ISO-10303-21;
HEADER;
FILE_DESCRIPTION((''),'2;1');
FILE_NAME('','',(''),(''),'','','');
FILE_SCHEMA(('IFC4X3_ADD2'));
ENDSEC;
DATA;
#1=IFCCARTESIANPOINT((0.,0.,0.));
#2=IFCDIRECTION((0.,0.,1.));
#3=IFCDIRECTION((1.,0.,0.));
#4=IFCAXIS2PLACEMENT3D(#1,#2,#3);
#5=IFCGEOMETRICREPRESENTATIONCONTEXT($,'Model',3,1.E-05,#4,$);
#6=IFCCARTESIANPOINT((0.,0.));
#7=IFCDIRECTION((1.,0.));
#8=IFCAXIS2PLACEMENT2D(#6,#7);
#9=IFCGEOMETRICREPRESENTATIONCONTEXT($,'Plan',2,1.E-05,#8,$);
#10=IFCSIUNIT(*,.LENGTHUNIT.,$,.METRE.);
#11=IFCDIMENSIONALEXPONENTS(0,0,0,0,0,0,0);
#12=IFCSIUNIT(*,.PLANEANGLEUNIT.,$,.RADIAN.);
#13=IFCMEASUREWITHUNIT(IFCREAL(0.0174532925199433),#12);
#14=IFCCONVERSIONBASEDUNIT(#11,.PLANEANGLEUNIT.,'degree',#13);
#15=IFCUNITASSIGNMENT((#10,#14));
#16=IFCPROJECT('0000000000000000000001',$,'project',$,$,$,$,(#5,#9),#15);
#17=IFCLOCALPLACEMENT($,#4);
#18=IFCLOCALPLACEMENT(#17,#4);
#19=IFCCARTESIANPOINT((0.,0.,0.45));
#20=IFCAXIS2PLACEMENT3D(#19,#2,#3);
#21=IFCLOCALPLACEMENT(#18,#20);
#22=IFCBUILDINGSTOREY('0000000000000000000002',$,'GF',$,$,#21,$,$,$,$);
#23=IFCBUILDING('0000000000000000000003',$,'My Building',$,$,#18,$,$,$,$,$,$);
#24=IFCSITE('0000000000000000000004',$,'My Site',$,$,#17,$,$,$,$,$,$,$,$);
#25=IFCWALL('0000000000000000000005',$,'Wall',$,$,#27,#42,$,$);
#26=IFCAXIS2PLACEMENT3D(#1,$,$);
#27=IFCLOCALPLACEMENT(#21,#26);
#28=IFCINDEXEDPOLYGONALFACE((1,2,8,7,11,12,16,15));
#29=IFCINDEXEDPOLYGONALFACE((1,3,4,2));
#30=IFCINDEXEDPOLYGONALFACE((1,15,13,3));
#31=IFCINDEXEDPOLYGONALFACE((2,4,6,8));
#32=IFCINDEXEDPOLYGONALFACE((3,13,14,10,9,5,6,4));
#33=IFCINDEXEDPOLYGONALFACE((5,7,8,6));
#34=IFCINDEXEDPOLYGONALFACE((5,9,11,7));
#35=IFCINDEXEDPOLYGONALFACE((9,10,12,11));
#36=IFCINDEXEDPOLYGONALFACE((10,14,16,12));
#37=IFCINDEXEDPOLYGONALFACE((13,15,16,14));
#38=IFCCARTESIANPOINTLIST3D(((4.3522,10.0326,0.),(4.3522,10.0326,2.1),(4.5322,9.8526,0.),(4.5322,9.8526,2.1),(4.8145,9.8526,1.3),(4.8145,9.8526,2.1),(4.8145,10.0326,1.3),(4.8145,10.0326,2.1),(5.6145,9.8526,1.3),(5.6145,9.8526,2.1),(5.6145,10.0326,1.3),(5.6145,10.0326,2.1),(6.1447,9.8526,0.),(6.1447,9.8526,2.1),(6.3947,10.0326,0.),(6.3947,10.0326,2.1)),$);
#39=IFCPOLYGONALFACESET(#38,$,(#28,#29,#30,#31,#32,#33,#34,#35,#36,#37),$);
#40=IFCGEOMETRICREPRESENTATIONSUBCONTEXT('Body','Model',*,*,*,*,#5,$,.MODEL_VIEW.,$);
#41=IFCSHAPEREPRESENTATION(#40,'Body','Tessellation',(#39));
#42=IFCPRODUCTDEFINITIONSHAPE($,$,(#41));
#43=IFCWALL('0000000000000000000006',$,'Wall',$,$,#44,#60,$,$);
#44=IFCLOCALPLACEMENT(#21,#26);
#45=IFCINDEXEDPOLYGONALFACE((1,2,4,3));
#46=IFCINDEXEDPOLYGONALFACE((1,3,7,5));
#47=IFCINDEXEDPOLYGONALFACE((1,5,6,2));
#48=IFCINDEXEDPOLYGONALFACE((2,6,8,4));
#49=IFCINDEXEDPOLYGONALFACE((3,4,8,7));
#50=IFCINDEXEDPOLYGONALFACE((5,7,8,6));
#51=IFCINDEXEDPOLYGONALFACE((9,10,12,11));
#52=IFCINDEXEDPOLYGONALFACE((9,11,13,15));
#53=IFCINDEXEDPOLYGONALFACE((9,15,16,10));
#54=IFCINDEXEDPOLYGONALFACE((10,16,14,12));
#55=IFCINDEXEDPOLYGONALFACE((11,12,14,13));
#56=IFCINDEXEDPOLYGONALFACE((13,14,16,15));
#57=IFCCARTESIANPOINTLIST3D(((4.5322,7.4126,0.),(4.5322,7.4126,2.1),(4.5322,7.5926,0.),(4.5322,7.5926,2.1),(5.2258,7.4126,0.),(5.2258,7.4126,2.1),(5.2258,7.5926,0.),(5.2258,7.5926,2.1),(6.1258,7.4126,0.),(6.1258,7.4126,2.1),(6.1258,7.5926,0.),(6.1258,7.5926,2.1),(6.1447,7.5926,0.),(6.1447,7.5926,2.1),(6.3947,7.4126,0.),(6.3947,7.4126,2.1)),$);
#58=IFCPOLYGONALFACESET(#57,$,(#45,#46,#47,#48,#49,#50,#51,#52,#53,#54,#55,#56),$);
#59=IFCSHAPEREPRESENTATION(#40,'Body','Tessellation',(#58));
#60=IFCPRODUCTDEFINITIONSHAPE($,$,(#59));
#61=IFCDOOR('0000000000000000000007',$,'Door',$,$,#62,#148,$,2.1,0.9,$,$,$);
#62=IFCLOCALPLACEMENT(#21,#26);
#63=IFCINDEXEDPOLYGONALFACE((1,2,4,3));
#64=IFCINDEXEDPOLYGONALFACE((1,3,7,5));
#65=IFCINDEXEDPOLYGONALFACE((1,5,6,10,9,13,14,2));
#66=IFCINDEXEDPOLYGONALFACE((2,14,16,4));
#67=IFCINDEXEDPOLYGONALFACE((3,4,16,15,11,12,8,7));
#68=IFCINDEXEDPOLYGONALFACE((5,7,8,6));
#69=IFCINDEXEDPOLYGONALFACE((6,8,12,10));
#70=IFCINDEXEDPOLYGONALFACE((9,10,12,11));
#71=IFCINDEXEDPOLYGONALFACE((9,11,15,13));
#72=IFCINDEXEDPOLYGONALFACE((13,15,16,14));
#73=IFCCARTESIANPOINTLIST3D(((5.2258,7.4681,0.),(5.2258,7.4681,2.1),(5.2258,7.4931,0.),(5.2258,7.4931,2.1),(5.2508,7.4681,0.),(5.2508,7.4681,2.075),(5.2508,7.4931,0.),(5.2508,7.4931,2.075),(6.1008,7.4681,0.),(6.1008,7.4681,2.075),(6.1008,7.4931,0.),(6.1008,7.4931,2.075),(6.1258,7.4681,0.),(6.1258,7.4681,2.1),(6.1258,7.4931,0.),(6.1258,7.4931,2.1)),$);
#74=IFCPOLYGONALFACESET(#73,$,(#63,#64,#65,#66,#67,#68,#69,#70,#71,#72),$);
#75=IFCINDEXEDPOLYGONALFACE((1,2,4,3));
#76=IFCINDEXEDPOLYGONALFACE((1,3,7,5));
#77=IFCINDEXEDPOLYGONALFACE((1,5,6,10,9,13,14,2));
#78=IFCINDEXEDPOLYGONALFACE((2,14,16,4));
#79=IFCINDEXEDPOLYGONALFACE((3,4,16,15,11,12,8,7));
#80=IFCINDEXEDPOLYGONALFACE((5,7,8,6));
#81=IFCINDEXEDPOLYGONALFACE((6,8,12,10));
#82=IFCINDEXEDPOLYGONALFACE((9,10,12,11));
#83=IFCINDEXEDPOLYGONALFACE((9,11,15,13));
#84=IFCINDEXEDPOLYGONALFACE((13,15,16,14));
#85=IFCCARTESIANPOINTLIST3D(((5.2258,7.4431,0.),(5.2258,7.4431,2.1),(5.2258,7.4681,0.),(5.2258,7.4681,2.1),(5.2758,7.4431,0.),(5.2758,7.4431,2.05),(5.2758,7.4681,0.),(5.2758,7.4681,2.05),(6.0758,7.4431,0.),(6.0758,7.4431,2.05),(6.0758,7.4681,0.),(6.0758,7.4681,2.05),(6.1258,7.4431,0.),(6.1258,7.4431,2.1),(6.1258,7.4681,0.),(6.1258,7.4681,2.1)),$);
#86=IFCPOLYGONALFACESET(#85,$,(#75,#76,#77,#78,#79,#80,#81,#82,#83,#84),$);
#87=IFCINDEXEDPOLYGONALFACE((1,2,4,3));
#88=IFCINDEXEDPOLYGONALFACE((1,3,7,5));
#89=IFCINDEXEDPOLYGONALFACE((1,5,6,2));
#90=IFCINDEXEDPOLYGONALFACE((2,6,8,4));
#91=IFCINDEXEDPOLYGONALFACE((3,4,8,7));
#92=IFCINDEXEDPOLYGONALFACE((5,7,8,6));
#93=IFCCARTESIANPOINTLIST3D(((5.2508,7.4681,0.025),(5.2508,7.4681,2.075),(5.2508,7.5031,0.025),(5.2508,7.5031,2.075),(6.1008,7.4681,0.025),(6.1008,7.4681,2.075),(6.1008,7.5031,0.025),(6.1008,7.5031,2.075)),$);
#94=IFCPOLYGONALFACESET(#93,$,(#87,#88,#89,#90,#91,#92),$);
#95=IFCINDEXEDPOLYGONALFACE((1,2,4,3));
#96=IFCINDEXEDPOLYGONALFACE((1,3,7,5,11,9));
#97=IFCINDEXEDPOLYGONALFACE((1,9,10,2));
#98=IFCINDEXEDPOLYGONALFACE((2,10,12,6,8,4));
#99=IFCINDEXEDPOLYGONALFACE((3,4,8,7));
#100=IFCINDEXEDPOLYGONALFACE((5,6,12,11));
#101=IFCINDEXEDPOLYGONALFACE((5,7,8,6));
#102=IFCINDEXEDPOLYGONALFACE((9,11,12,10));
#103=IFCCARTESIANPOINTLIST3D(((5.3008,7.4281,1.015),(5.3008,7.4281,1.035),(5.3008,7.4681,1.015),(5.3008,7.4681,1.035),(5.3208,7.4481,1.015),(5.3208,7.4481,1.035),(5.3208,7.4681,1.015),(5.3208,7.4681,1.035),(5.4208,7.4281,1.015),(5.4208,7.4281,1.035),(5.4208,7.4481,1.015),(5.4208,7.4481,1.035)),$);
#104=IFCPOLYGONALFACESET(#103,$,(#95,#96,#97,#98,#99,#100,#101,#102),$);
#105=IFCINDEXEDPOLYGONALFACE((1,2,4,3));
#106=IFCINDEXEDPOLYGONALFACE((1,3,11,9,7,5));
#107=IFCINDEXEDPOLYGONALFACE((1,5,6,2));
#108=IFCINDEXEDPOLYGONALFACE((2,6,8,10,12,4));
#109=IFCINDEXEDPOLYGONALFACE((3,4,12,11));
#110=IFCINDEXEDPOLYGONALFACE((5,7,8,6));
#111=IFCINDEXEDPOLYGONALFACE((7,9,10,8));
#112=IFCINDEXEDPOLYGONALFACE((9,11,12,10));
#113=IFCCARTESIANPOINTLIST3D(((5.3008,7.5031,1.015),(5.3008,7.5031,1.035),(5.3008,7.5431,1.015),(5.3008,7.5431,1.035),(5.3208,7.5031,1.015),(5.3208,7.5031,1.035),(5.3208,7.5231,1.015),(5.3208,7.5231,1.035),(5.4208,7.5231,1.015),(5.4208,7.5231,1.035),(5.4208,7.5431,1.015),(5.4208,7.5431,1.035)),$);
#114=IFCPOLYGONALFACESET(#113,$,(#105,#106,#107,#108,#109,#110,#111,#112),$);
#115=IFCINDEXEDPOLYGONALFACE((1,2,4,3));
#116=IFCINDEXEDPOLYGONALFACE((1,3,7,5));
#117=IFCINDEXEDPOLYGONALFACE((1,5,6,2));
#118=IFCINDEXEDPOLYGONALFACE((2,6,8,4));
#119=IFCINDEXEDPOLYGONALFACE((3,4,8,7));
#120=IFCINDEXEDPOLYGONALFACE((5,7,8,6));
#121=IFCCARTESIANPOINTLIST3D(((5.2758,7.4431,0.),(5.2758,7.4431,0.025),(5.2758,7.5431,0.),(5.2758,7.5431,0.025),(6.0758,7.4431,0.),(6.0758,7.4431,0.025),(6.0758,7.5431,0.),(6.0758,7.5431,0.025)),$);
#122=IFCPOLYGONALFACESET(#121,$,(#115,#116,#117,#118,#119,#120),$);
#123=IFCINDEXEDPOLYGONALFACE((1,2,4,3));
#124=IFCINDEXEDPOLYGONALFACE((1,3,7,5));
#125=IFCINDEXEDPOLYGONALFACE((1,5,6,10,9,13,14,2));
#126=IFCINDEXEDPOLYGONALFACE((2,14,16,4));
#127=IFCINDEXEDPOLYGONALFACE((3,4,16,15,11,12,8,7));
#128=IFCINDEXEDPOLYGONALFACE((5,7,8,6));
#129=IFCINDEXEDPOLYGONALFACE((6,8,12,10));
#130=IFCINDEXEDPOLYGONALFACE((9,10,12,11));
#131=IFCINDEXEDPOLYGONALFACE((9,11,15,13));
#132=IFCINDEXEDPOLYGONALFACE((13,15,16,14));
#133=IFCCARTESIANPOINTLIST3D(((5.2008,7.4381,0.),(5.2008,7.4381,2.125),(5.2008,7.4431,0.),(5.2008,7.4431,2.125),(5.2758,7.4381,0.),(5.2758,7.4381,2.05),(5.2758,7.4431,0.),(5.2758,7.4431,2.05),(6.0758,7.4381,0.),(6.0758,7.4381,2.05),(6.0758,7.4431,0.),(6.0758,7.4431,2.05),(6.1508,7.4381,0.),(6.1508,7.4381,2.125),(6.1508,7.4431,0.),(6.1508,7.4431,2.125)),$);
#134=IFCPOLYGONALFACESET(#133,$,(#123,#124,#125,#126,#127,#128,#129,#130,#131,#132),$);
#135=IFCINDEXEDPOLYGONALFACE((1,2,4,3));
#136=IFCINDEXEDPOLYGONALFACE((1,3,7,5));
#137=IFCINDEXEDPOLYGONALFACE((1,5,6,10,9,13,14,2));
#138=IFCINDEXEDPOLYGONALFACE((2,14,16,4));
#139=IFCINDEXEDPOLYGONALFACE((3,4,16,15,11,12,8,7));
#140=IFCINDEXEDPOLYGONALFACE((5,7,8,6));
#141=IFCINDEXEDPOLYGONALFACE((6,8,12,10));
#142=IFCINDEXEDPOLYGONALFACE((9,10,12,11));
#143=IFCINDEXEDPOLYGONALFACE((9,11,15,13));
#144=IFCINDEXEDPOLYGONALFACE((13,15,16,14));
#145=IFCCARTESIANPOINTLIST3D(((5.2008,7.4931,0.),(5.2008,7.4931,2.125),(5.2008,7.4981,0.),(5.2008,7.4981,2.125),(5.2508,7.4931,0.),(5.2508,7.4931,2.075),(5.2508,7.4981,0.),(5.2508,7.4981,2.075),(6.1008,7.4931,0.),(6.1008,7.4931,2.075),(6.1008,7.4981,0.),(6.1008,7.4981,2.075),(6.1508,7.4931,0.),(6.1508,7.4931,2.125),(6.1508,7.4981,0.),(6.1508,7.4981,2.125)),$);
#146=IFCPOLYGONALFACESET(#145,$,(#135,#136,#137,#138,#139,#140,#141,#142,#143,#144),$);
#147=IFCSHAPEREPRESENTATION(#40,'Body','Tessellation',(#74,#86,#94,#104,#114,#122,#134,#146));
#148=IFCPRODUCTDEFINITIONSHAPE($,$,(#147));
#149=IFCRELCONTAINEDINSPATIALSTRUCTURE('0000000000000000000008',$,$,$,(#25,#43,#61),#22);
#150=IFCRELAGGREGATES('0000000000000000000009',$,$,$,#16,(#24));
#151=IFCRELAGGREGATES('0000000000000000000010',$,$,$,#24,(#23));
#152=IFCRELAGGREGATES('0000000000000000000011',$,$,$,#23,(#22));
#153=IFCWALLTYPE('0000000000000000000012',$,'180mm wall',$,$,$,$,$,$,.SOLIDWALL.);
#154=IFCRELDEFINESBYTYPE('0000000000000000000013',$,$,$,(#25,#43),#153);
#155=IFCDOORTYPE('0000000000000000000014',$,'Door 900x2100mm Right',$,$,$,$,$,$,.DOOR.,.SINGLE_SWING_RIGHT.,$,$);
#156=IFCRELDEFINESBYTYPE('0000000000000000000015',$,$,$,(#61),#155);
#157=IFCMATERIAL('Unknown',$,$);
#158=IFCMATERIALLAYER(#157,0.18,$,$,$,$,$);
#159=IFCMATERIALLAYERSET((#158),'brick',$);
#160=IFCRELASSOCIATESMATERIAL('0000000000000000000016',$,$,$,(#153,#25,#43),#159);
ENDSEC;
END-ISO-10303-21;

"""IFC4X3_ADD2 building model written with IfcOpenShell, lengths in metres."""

from ifc_helpers import new_model, entity, si_unit, converted_unit, frame, origin_with_axes, origin_2d_with_axis, place, context, subcontext, project, spatial, line, indexed_curve, outline, extrude, shape, source, transform, mapped, material, layer, layer_set, layer_usage, type_object, type_shapes, element, fill, save


model = new_model("IFC4X3_ADD2")

# Units and contexts
model_context = context("Model", 3, precision=1e-05, world=origin_with_axes())
plan_context = context("Plan", 2, precision=1e-05, world=origin_2d_with_axis())
body_context_1 = subcontext(model_context, "Body", "Model", "MODEL_VIEW")
body_context_2 = subcontext(plan_context, "Body", "Plan", "PLAN_VIEW")
ifc_project = project(units=[si_unit("LENGTHUNIT", "METRE"), converted_unit("PLANEANGLEUNIT", "degree", entity("IfcReal", 0.0174532925199433), si_unit("PLANEANGLEUNIT", "RADIAN"), dimensions=[0, 0, 0, 0, 0, 0, 0])], contexts=[model_context, plan_context])

# Site, building, storey
site_placement = place(None, origin_with_axes())
site = spatial("IfcSite", under=ifc_project, at=site_placement, Name="My Site")
building_placement = place(site_placement, origin_with_axes())
building = spatial("IfcBuilding", under=site, at=building_placement, Name="My Building")
storey_placement = place(building_placement, frame((0.0, 0.0, 0.45), z_axis=(0.0, 0.0, 1.0), x_axis=(1.0, 0.0, 0.0)))
storey = spatial("IfcBuildingStorey", under=building, at=storey_placement, Name="GF")

# Shared definitions
ifc_material_1 = material(Name="Unknown")
shared_shape_1 = source(origin_with_axes(), body_context_1, "Body", "SweptSolid", [
    extrude(outline(indexed_curve([(0.0, 0.0), (0.8, 0.0), (0.8, 0.8), (0.0, 0.8)], segments=[line(1, 2, 3, 4, 1)])), frame((-0.4, -0.6, 0.0), z_axis=(0.0, -1.0, 0.0), x_axis=(1.0, 0.0, 0.0)), (0.0, 0.0, -1.0), 1.2),
])

# Shared definitions
shared_shape_2 = source(origin_with_axes(), body_context_1, "Body", "SolidModel", [
    extrude(outline(indexed_curve([(0.0, 0.0), (0.9, 0.0), (0.9, 2.1), (0.0, 2.1)], segments=[line(1, 2, 3, 4, 1)])), frame((0.0, -0.6, 0.0), z_axis=(0.0, -1.0, 0.0), x_axis=(1.0, 0.0, 0.0)), (0.0, 0.0, -1.0), 1.2),
])
door_type_1 = type_object("IfcDoorType", Name="Door 900x2100mm Right", OperationType="SINGLE_SWING_RIGHT", PredefinedType="DOOR")
shared_shape_3 = source(origin_with_axes(), body_context_1, "Body", "SweptSolid", [
    extrude(outline(indexed_curve([(0.0, 0.0), (0.0, 2.1), (0.9, 2.1), (0.9, 0.0), (0.875, 0.0), (0.875, 2.075), (0.025, 2.075), (0.025, 0.0)], segments=[line(1, 2, 3, 4, 5, 6, 7, 8, 1)])), frame((0.0, 0.025, 0.0), z_axis=(0.0, -1.0, 0.0), x_axis=(1.0, 0.0, 0.0)), (0.0, 0.0, -1.0), 0.025),
    extrude(outline(indexed_curve([(0.0, 0.0), (0.0, 2.1), (0.9, 2.1), (0.9, 0.0), (0.85, 0.0), (0.85, 2.05), (0.05, 2.05), (0.05, 0.0)], segments=[line(1, 2, 3, 4, 5, 6, 7, 8, 1)])), frame((0.0, 0.0, 0.0), z_axis=(0.0, -1.0, 0.0), x_axis=(1.0, 0.0, 0.0)), (0.0, 0.0, -1.0), 0.025),
    extrude(outline(indexed_curve([(0.0, 0.0), (0.85, 0.0), (0.85, 0.035), (0.0, 0.035)], segments=[line(1, 2, 3, 4, 1)])), frame((0.025, 0.025, 0.025), z_axis=(0.0, 0.0, 1.0), x_axis=(1.0, 0.0, 0.0)), (0.0, 0.0, 1.0), 2.05),
    extrude(outline(indexed_curve([(0.0, 0.0), (0.0, -0.04), (0.12, -0.04), (0.12, -0.02), (0.02, -0.02), (0.02, 0.0)], segments=[line(1, 2, 3, 4, 5, 6, 1)])), frame((0.075, 0.025, 1.015), z_axis=(0.0, 0.0, 1.0), x_axis=(1.0, 0.0, 0.0)), (0.0, 0.0, 1.0), 0.02),
    extrude(outline(indexed_curve([(0.0, 0.0), (0.0, 0.04), (0.12, 0.04), (0.12, 0.02), (0.02, 0.02), (0.02, 0.0)], segments=[line(1, 2, 3, 4, 5, 6, 1)])), frame((0.075, 0.06, 1.015), z_axis=(0.0, 0.0, 1.0), x_axis=(1.0, 0.0, 0.0)), (0.0, 0.0, 1.0), 0.02),
    extrude(outline(indexed_curve([(0.0, 0.0), (0.8, 0.0), (0.8, 0.1), (0.0, 0.1)], segments=[line(1, 2, 3, 4, 1)])), frame((0.05, 0.0, 0.0), z_axis=(0.0, 0.0, 1.0), x_axis=(1.0, 0.0, 0.0)), (0.0, 0.0, 1.0), 0.025),
    extrude(outline(indexed_curve([(0.0, 0.0), (0.0, 2.125), (0.95, 2.125), (0.95, 0.0), (0.875, 0.0), (0.875, 2.05), (0.075, 2.05), (0.075, 0.0)], segments=[line(1, 2, 3, 4, 5, 6, 7, 8, 1)])), frame((-0.025, -0.005, 0.0), z_axis=(0.0, -1.0, 0.0), x_axis=(1.0, 0.0, 0.0)), (0.0, 0.0, -1.0), 0.005),
    extrude(outline(indexed_curve([(0.0, 0.0), (0.0, 2.125), (0.95, 2.125), (0.95, 0.0), (0.9, 0.0), (0.9, 2.075), (0.05, 2.075), (0.05, 0.0)], segments=[line(1, 2, 3, 4, 5, 6, 7, 8, 1)])), frame((-0.025, 0.05, 0.0), z_axis=(0.0, -1.0, 0.0), x_axis=(1.0, 0.0, 0.0)), (0.0, 0.0, -1.0), 0.005),
])
shared_shape_4 = source(origin_with_axes(), body_context_2, "Body", "Curve2D", [
    entity("IfcIndexedPolyCurve", entity("IfcCartesianPointList2D", [[0.0, 0.0], [0.0, 0.05], [0.025, 0.05], [0.025, 0.025], [0.05, 0.025], [0.05, 0.0]]), [entity("IfcLineIndex", [1, 2, 3, 4, 5, 6, 1])]),
    entity("IfcIndexedPolyCurve", entity("IfcCartesianPointList2D", [[0.9, 0.0], [0.9, 0.05], [0.875, 0.05], [0.875, 0.025], [0.85, 0.025], [0.85, 0.0]]), [entity("IfcLineIndex", [1, 2, 3, 4, 5, 6, 1])]),
    entity("IfcTrimmedCurve", entity("IfcEllipse", entity("IfcAxis2Placement2D", entity("IfcCartesianPoint", [0.84, 0.05]), entity("IfcDirection", [1.0, 0.0])), 0.815, 0.85), [entity("IfcCartesianPoint", [0.84, 0.9])], [entity("IfcCartesianPoint", [0.025, 0.05])], True, "CARTESIAN"),
    entity("IfcIndexedPolyCurve", entity("IfcCartesianPointList2D", [[0.875, 0.05], [0.84, 0.05], [0.84, 0.9], [0.875, 0.9]]), [entity("IfcLineIndex", [1, 2, 3, 4, 1])]),
])
type_shapes(door_type_1, [shared_shape_3, shared_shape_4])

# Wall, opening
ifc_layer_1 = layer(ifc_material_1, 0.18)
ifc_layer_set_1 = layer_set([ifc_layer_1], Name="brick")
ifc_layer_usage_1 = layer_usage(ifc_layer_set_1, "AXIS2", "POSITIVE", 0.0)
wall_type_1 = type_object("IfcWallType", Name="180mm wall", PredefinedType="SOLIDWALL", material=ifc_layer_set_1)
wall_1_placement = place(storey_placement, frame((6.3947, 10.0326, 0.0), z_axis=(0.0, 0.0, 1.0), x_axis=(-1.0, 0.0, 0.0)))
wall_1 = element("IfcWall", 1, at=wall_1_placement, inside=storey, type_object=wall_type_1, material=ifc_layer_usage_1, Name="Wall", context=body_context_1, shape_type="SweptSolid", body=[
    extrude(outline(indexed_curve([(0.0, 0.0), (0.25, 0.18), (1.8625, 0.18), (2.0425, 0.0)], segments=[line(1, 2, 3, 4, 1)])), origin_with_axes(), (0.0, 0.0, 1.0), 2.1),
])
opening_1_placement = place(wall_1_placement, frame((1.1802, 0.0422, 1.3), z_axis=(0.0, 0.0, 1.0), x_axis=(1.0, 0.0, 0.0)))
element("IfcOpeningElement", 2, at=opening_1_placement, cuts=wall_1, PredefinedType="OPENING", context=body_context_1, shape_type="MappedRepresentation", body=[
    mapped(shared_shape_1, transform((0.0, 0.0, 0.0), x_axis=(1.0, 0.0, 0.0), y_axis=(0.0, 1.0, 0.0), z_axis=(0.0, 0.0, 1.0), scale=1.0)),
])

# Wall, opening, door
ifc_layer_usage_2 = layer_usage(ifc_layer_set_1, "AXIS2", "POSITIVE", 0.0)
wall_2_placement = place(storey_placement, frame((6.3947, 7.5926, 0.0), z_axis=(0.0, 0.0, 1.0), x_axis=(-1.0, 0.0, 0.0)))
wall_2 = element("IfcWall", 3, at=wall_2_placement, inside=storey, type_object=wall_type_1, material=ifc_layer_usage_2, Name="Wall", context=body_context_1, shape_type="SweptSolid", body=[
    extrude(outline(indexed_curve([(0.25, 0.0), (0.0, 0.18), (1.8625, 0.18), (1.8625, 0.0)], segments=[line(1, 2, 3, 4, 1)])), origin_with_axes(), (0.0, 0.0, 1.0), 2.1),
])
opening_2_placement = place(wall_2_placement, frame((1.1688, 0.1495, 0.0), z_axis=(0.0, 0.0, 1.0), x_axis=(-1.0, 0.0, 0.0)))
opening_2 = element("IfcOpeningElement", 4, at=opening_2_placement, cuts=wall_2, PredefinedType="OPENING", context=body_context_1, shape_type="MappedRepresentation", body=[
    mapped(shared_shape_2, transform((0.0, 0.0, 0.0), x_axis=(1.0, 0.0, 0.0), y_axis=(0.0, 1.0, 0.0), z_axis=(0.0, 0.0, 1.0), scale=1.0)),
])
door_1_placement = place(opening_2_placement, frame((0.0, 0.0, 0.0), z_axis=(0.0, 0.0, 1.0), x_axis=(1.0, 0.0, 0.0)))
door_1 = element("IfcDoor", 5, at=door_1_placement, inside=storey, type_object=door_type_1, Name="Door", OverallHeight=2.1, OverallWidth=0.9, shapes=[
    shape(body_context_1, "Body", "MappedRepresentation", [mapped(shared_shape_3, transform((0.0, 0.0, 0.0), x_axis=(1.0, 0.0, 0.0), y_axis=(0.0, 1.0, 0.0), z_axis=(0.0, 0.0, 1.0), scale=1.0))]),
    shape(body_context_2, "Body", "MappedRepresentation", [mapped(shared_shape_4, transform((0.0, 0.0, 0.0), x_axis=(1.0, 0.0, 0.0), y_axis=(0.0, 1.0, 0.0), z_axis=(0.0, 0.0, 1.0), scale=1.0))]),
])
fill(opening_2, door_1)

save(model, "model.ifc")
